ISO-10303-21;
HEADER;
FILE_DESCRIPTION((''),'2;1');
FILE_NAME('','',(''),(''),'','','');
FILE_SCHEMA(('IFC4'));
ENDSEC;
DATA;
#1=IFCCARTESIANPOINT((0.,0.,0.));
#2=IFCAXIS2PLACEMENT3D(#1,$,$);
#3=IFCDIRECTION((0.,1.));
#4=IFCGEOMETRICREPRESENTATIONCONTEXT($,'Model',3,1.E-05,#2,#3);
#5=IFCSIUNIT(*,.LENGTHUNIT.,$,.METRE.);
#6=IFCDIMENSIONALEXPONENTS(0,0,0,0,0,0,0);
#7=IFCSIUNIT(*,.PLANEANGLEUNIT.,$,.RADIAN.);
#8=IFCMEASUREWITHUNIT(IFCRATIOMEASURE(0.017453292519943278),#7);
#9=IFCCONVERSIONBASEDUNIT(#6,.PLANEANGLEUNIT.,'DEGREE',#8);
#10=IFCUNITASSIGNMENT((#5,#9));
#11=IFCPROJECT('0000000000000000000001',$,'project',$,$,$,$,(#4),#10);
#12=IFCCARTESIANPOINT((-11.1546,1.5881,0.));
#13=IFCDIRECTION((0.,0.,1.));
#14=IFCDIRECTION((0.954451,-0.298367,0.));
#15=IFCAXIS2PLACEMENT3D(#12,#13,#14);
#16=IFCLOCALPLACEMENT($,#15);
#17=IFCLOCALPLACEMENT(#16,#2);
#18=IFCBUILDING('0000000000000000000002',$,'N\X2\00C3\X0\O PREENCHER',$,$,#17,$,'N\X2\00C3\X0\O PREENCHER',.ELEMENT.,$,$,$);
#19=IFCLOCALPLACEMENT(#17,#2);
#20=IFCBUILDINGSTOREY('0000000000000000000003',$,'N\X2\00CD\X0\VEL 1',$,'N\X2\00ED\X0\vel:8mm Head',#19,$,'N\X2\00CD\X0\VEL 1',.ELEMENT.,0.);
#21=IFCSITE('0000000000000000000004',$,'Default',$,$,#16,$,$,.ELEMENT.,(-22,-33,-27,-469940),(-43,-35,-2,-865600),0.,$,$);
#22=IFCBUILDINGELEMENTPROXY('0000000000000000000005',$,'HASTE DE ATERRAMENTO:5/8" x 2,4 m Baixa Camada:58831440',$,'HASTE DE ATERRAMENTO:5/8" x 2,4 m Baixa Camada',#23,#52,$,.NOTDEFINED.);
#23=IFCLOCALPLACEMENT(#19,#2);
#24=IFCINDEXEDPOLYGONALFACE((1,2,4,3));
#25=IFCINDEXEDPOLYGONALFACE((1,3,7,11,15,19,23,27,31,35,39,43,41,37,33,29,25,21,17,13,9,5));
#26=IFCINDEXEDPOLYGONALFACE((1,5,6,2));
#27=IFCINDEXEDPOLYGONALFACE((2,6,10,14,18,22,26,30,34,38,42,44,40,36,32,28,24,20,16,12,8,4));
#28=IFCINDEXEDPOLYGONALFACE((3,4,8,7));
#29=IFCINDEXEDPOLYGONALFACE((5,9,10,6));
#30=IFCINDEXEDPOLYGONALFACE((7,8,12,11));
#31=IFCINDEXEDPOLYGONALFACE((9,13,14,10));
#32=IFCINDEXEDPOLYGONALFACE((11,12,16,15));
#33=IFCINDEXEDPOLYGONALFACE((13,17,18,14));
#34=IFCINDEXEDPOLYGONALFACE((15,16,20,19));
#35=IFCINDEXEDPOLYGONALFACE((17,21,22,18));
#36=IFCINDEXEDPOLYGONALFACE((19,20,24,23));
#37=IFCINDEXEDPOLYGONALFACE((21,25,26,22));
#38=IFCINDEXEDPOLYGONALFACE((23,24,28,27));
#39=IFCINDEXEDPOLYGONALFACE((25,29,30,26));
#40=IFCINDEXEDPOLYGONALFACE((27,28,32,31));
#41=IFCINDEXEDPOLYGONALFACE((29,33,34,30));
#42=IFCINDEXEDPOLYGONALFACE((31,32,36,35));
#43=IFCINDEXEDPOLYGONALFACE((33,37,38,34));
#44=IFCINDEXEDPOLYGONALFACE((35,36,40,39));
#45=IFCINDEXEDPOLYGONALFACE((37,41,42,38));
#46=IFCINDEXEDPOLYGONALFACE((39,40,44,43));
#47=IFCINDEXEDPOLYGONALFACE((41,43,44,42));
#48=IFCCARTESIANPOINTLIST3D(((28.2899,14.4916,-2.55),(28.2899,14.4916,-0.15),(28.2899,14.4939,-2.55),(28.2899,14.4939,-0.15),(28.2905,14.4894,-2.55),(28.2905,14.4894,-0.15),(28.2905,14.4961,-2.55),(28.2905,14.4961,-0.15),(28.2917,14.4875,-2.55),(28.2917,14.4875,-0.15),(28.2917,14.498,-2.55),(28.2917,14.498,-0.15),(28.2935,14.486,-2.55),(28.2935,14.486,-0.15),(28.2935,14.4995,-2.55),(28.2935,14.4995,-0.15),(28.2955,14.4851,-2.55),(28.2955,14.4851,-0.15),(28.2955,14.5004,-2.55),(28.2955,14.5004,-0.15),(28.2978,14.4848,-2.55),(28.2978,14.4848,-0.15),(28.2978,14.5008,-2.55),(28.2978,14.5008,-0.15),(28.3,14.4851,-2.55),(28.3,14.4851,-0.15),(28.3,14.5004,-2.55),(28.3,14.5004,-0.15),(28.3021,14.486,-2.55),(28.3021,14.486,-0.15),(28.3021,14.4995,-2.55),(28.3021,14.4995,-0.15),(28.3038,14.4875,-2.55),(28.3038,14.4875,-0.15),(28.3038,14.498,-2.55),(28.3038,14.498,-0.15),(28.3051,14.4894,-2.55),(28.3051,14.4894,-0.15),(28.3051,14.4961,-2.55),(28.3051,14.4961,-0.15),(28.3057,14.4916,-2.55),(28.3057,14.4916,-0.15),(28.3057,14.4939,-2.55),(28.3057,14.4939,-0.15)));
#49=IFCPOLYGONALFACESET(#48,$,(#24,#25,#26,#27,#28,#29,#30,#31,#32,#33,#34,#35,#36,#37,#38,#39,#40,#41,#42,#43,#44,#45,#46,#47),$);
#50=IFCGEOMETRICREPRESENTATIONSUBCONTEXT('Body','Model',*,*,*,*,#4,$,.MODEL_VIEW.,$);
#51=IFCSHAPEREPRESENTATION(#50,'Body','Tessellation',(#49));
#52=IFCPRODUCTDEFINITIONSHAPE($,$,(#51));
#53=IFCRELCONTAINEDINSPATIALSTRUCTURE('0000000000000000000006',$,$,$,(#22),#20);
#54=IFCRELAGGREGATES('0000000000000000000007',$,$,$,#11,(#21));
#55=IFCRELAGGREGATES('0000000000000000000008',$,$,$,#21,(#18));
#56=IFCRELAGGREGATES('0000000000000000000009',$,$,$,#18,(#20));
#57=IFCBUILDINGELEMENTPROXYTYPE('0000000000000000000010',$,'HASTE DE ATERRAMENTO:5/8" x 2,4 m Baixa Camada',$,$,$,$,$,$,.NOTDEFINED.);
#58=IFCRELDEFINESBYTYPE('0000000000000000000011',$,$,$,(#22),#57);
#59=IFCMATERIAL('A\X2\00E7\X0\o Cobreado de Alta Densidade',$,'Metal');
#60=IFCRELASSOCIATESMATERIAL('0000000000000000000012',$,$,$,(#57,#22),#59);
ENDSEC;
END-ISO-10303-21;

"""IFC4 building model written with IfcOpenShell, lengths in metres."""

from ifc_helpers import new_model, entity, si_unit, converted_unit, direction, frame, origin, place, context, subcontext, project, spatial, arc, indexed_curve, outline, extrude, source, transform, mapped, material, type_object, type_shapes, element, save


model = new_model("IFC4")

# Units and contexts
model_context = context("Model", 3, precision=1e-05, world=origin(), true_north=direction((0.0, 1.0)))
body_context = subcontext(model_context, "Body", "Model", "MODEL_VIEW")
ifc_project = project(units=[si_unit("LENGTHUNIT", "METRE"), converted_unit("PLANEANGLEUNIT", "DEGREE", entity("IfcRatioMeasure", 0.017453292519943278), si_unit("PLANEANGLEUNIT", "RADIAN"), dimensions=[0, 0, 0, 0, 0, 0, 0])], contexts=[model_context])

# Site, building, storey
site_placement = place(None, frame((-11.1546, 1.5881, 0.0), z_axis=(0.0, 0.0, 1.0), x_axis=(0.954451, -0.298367, 0.0)))
site = spatial("IfcSite", under=ifc_project, at=site_placement, Name="Default", CompositionType="ELEMENT", RefLatitude=(-22, -33, -27, -469940), RefLongitude=(-43, -35, -2, -865600), RefElevation=0.0)
building_placement = place(site_placement, origin())
building = spatial("IfcBuilding", under=site, at=building_placement, Name="NÃO PREENCHER", LongName="NÃO PREENCHER", CompositionType="ELEMENT")
storey_placement = place(building_placement, origin())
storey = spatial("IfcBuildingStorey", under=building, at=storey_placement, Name="NÍVEL 1", ObjectType="Nível:8mm Head", LongName="NÍVEL 1", CompositionType="ELEMENT", Elevation=0.0)

# Building element proxy
ifc_material_1 = material(Name="Aço Cobreado de Alta Densidade", Category="Metal")
building_element_proxy_type_1 = type_object("IfcBuildingElementProxyType", Name="HASTE DE ATERRAMENTO:5/8\" x 2,4 m Baixa Camada", PredefinedType="NOTDEFINED", material=ifc_material_1)
shared_shape_1 = source(origin(), body_context, "Body", "SweptSolid", [
    extrude(outline(indexed_curve([(-0.008, 0.0), (0.0, -0.008), (0.008, 0.0), (0.0, 0.008)], segments=[arc(1, 2, 3), arc(3, 4, 1)], self_intersect=False)), frame((0.0096, 0.0096, 0.0)), (0.0, 0.0, 1.0), 2.4),
])
type_shapes(building_element_proxy_type_1, [shared_shape_1])
proxy_1_placement = place(storey_placement, frame((28.3074, 14.4832, -2.55), z_axis=(0.0, 0.0, 1.0), x_axis=(0.0, 1.0, 0.0)))
element("IfcBuildingElementProxy", 1, at=proxy_1_placement, inside=storey, type_object=building_element_proxy_type_1, material=ifc_material_1, Name="HASTE DE ATERRAMENTO:5/8\" x 2,4 m Baixa Camada:58831440", ObjectType="HASTE DE ATERRAMENTO:5/8\" x 2,4 m Baixa Camada", PredefinedType="NOTDEFINED", context=body_context, shape_type="MappedRepresentation", body=[
    mapped(shared_shape_1, transform((0.0, 0.0, 0.0), scale=1.0)),
])

save(model, "model.ifc")
